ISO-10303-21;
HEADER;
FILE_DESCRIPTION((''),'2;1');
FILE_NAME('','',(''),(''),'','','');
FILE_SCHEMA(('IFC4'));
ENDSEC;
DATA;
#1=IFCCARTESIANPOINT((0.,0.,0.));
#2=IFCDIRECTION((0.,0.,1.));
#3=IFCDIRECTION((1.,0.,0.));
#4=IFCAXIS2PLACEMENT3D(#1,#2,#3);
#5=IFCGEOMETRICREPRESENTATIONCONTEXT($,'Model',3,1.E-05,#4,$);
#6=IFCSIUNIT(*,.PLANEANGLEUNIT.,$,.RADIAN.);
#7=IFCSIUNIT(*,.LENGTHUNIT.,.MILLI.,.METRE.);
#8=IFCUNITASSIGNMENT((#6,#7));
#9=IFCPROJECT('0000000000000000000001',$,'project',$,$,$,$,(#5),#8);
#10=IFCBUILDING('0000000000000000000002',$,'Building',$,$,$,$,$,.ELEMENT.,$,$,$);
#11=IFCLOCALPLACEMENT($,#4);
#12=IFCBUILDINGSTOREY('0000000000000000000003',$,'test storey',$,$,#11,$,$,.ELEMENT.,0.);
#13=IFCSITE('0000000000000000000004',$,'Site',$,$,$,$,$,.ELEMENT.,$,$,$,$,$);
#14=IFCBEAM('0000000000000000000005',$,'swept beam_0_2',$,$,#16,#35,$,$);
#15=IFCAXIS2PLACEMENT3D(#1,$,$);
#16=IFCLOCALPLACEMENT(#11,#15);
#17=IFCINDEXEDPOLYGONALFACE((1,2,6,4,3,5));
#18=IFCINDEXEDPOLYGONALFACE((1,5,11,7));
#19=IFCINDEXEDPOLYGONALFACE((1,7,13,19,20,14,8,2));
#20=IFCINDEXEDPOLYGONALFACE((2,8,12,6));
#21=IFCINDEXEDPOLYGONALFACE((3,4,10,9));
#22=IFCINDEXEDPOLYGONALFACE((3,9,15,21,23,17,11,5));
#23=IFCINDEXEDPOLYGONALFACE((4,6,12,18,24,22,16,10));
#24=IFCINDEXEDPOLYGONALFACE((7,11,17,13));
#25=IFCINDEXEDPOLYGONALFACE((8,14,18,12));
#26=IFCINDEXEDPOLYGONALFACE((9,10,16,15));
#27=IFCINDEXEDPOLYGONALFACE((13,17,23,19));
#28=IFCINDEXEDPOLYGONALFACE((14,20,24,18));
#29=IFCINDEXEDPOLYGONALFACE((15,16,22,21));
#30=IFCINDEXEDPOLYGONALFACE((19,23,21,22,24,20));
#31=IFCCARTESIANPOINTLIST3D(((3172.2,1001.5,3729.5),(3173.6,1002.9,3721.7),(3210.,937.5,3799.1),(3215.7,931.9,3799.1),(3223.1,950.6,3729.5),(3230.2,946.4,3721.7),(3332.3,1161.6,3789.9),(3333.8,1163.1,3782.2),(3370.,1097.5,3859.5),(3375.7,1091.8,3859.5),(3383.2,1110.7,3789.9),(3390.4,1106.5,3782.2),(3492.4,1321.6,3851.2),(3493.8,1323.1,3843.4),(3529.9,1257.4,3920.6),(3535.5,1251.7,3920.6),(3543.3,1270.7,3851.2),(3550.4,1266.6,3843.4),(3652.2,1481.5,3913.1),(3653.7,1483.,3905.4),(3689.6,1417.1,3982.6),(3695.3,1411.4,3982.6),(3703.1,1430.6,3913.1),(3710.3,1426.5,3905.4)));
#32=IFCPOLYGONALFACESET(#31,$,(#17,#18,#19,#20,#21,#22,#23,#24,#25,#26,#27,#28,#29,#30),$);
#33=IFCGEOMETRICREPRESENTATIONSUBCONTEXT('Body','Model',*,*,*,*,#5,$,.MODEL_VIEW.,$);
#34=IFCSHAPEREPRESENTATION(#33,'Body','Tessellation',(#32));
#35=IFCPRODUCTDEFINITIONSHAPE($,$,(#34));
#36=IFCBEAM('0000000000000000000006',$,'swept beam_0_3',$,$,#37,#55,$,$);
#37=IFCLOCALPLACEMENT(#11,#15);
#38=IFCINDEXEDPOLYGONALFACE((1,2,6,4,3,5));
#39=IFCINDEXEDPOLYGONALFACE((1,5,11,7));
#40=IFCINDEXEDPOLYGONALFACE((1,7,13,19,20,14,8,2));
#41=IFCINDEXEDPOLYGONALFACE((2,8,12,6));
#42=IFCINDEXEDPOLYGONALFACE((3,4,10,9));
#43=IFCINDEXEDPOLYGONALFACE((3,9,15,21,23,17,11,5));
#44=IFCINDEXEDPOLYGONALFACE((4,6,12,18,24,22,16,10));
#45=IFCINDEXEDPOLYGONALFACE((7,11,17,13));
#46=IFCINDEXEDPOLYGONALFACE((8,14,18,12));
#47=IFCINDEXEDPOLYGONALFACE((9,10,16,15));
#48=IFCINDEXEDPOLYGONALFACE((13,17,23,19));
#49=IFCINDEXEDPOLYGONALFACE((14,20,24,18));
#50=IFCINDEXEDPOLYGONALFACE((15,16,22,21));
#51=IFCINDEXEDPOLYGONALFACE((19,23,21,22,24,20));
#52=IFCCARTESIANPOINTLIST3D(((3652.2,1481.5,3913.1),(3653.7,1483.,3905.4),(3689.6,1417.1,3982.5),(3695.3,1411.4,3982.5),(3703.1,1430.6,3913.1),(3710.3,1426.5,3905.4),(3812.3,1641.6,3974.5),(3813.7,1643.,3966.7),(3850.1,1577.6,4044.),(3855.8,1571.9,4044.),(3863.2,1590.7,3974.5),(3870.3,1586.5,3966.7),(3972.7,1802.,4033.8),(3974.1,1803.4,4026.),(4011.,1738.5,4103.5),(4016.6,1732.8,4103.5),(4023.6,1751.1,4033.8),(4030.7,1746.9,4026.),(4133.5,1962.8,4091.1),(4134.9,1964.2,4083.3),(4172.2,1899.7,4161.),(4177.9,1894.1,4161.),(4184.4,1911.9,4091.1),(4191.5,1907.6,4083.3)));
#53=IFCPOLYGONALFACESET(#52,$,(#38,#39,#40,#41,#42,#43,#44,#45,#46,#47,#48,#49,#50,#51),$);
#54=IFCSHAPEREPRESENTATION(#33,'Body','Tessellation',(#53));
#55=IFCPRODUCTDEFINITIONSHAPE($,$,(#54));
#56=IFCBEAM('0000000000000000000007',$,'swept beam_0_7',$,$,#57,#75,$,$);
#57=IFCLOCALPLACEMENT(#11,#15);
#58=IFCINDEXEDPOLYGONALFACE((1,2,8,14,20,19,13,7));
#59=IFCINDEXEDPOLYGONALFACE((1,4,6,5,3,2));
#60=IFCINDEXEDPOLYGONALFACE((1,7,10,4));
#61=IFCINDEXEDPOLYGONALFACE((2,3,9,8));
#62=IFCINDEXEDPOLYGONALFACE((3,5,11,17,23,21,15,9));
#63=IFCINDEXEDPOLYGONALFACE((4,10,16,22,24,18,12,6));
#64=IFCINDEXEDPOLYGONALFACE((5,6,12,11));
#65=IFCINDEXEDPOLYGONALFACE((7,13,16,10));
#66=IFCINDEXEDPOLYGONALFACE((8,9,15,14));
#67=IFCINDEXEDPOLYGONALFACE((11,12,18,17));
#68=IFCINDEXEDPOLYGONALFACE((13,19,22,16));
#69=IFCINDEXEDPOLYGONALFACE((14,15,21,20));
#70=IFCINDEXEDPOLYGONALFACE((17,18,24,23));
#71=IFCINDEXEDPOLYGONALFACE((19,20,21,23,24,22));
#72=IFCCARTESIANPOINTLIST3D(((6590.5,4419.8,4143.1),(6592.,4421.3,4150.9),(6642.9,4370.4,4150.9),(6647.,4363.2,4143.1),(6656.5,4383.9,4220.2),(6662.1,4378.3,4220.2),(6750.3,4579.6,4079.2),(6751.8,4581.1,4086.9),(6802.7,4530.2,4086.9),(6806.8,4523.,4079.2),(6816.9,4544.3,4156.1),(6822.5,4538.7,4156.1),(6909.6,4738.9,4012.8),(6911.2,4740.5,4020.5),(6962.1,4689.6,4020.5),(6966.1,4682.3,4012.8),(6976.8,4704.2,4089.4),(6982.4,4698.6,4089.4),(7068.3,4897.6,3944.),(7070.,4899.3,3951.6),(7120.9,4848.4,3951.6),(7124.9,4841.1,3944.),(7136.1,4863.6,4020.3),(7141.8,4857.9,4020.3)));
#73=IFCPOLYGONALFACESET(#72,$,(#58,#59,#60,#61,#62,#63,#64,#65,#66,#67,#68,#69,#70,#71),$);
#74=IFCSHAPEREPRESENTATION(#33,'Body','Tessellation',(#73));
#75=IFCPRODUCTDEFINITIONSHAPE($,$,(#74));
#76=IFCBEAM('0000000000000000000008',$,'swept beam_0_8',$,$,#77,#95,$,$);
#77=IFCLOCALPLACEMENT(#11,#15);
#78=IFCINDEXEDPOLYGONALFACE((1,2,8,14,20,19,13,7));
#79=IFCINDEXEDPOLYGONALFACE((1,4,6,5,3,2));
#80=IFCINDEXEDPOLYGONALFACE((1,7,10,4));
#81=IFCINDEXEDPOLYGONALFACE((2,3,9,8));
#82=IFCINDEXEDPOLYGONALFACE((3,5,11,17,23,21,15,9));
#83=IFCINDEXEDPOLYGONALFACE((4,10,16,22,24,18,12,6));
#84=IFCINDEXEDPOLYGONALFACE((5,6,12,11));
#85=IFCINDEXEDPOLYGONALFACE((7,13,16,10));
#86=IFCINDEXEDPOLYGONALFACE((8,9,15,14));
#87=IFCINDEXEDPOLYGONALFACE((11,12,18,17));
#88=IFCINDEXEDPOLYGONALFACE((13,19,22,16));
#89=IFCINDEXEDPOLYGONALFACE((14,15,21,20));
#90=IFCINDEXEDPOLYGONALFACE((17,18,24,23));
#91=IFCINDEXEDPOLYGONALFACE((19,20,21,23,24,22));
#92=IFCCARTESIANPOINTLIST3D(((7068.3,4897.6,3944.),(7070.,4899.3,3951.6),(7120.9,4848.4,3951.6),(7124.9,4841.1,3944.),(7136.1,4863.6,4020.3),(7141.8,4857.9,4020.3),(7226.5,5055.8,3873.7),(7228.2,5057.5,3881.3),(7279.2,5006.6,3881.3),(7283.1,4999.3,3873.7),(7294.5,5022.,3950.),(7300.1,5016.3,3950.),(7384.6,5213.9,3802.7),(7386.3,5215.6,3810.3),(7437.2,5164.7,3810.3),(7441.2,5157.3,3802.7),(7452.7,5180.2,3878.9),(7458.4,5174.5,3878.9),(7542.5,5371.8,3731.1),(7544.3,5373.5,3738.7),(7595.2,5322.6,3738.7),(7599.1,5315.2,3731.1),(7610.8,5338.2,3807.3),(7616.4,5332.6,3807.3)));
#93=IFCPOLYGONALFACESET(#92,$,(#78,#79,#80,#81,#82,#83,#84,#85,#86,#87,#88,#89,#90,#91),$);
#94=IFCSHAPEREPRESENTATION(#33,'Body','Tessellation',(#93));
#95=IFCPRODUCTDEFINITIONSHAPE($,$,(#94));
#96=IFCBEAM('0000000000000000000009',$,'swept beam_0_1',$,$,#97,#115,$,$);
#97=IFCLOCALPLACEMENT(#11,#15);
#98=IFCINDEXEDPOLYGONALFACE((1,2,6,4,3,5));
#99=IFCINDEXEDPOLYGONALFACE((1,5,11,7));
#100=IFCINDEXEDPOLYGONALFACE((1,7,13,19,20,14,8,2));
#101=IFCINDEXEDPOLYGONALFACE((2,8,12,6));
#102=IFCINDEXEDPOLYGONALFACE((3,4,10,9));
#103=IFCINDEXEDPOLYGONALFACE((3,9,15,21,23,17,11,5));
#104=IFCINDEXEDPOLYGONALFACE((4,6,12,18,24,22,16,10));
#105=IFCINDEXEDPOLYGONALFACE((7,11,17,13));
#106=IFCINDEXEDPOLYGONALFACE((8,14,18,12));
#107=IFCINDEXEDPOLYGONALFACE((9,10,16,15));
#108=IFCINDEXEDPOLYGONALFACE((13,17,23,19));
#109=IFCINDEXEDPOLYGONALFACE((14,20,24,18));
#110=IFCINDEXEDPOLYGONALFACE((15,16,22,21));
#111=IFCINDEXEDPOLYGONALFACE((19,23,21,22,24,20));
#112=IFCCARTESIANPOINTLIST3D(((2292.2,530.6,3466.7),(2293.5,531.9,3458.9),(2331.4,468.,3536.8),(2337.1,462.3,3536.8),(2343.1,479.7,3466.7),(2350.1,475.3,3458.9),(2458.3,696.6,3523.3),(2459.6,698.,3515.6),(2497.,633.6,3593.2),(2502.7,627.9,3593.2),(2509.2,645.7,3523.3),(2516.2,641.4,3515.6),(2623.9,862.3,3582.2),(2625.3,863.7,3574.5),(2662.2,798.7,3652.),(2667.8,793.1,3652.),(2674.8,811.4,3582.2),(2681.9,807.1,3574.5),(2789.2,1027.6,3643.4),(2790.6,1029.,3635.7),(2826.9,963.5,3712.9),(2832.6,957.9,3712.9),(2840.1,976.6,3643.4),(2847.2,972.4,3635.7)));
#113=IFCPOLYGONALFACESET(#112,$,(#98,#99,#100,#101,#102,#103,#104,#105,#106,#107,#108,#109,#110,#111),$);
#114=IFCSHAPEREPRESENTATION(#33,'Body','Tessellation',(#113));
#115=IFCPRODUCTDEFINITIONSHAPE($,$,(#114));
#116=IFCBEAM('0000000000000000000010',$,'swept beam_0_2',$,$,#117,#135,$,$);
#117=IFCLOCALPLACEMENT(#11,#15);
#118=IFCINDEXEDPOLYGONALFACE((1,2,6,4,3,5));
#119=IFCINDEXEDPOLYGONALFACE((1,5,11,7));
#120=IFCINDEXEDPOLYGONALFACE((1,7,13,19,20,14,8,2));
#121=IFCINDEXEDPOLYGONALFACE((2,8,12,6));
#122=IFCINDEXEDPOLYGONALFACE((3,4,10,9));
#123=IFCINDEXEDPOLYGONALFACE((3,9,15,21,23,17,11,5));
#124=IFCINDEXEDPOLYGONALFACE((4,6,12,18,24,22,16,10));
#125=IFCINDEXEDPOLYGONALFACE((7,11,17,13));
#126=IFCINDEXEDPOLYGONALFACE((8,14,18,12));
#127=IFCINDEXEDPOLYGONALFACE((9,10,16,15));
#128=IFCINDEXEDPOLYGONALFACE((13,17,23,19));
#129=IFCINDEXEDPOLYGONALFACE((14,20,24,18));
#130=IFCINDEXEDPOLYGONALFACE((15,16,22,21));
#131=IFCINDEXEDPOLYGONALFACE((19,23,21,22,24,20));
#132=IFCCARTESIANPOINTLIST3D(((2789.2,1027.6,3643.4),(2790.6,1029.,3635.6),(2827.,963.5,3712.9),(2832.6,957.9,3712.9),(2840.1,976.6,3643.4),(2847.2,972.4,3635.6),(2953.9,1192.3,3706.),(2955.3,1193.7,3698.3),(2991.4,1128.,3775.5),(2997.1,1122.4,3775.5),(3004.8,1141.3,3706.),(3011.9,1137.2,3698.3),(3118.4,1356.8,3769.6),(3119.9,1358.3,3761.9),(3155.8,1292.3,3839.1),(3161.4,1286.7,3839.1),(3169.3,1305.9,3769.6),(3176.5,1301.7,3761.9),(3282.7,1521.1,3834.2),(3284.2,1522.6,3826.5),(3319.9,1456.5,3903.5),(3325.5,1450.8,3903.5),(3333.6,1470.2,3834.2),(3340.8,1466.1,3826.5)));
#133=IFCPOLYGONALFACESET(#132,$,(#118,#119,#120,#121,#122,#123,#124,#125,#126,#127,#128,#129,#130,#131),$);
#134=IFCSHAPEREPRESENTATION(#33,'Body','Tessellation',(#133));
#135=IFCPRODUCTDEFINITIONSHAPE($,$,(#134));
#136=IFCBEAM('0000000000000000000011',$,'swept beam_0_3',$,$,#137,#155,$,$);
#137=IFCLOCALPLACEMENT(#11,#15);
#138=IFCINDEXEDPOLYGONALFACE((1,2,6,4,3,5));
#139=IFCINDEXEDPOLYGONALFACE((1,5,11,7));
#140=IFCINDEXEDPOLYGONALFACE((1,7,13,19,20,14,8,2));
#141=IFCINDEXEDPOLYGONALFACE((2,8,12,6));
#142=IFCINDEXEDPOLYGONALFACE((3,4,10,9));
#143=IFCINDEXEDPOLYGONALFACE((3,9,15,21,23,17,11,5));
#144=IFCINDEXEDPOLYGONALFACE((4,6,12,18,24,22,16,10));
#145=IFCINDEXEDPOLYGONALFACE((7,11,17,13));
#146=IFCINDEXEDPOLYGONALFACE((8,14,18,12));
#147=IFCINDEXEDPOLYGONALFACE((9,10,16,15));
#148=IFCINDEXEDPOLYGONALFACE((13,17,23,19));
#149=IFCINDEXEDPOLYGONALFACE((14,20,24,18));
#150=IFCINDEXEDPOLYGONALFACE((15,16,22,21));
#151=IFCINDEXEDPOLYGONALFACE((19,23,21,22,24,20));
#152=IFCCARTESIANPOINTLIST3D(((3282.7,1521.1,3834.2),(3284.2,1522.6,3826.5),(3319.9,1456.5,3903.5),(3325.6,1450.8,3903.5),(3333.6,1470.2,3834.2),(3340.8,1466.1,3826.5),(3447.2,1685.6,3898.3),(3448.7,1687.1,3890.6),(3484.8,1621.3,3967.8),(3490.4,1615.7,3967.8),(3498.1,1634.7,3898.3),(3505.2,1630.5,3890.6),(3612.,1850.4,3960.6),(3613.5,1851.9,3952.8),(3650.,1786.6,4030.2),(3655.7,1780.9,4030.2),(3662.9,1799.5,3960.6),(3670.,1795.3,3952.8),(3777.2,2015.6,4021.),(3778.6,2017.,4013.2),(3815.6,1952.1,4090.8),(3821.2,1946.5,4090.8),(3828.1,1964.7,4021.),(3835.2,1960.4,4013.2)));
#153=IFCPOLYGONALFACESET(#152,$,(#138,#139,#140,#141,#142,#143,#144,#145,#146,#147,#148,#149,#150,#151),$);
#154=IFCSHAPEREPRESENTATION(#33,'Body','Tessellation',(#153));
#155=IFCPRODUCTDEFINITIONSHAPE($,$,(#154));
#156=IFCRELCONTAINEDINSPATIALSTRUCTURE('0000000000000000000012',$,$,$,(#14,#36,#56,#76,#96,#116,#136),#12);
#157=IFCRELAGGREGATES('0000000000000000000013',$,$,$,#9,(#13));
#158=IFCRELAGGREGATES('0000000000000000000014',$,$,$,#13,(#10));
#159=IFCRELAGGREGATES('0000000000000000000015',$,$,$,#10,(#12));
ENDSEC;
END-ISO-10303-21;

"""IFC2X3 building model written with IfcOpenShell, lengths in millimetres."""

from ifc_helpers import new_model, entity, si_unit, origin_with_axes, place, context, subcontext, project, spatial, element, save


model = new_model("IFC2X3")

# Units and contexts
model_context = context("Model", 3, precision=1e-05, world=origin_with_axes())
body_context = subcontext(model_context, "Body", "Model", "MODEL_VIEW")
ifc_project = project(units=[si_unit("PLANEANGLEUNIT", "RADIAN"), si_unit("LENGTHUNIT", "METRE", prefix="MILLI")], contexts=[model_context])

# Site, building, storey
site = spatial("IfcSite", under=ifc_project, Name="Site", CompositionType="ELEMENT")
building = spatial("IfcBuilding", under=site, Name="Building", CompositionType="ELEMENT")
storey_placement = place(None, origin_with_axes())
storey = spatial("IfcBuildingStorey", under=building, at=storey_placement, Name="test storey", CompositionType="ELEMENT", Elevation=0.0)

# Beams
beam_1_placement = place(storey_placement, origin_with_axes())
element("IfcBeam", 1, at=beam_1_placement, inside=storey, Name="swept beam_0_2", context=body_context, shape_type="SweptSolid", body=[
    entity("IfcRevolvedAreaSolid", entity("IfcArbitraryClosedProfileDef", "AREA", None, entity("IfcPolyline", [entity("IfcCartesianPoint", [-80.0, 40.0]), entity("IfcCartesianPoint", [-80.0, 32.0]), entity("IfcCartesianPoint", [-8.0, 32.0]), entity("IfcCartesianPoint", [-8.0, -40.0]), entity("IfcCartesianPoint", [0.0, -40.0]), entity("IfcCartesianPoint", [0.0, 40.0]), entity("IfcCartesianPoint", [-80.0, 40.0])])), entity("IfcAxis2Placement3D", entity("IfcCartesianPoint", [3201.9, 974.6, 3721.7]), entity("IfcDirection", [-0.6835, -0.6835, -0.2564]), entity("IfcDirection", [0.1813, 0.1813, -0.9666])), entity("IfcAxis1Placement", entity("IfcCartesianPoint", [-70891.4, 0.0, 0.0]), entity("IfcDirection", [0.0, 1.0, 0.0])), 0.009922),
])
beam_2_placement = place(storey_placement, origin_with_axes())
element("IfcBeam", 2, at=beam_2_placement, inside=storey, Name="swept beam_0_3", context=body_context, shape_type="SweptSolid", body=[
    entity("IfcRevolvedAreaSolid", entity("IfcArbitraryClosedProfileDef", "AREA", None, entity("IfcPolyline", [entity("IfcCartesianPoint", [80.0, -40.0]), entity("IfcCartesianPoint", [80.0, -32.0]), entity("IfcCartesianPoint", [8.0, -32.0]), entity("IfcCartesianPoint", [8.0, 40.0]), entity("IfcCartesianPoint", [0.0, 40.0]), entity("IfcCartesianPoint", [0.0, -40.0]), entity("IfcCartesianPoint", [80.0, -40.0])])), entity("IfcAxis2Placement3D", entity("IfcCartesianPoint", [3682.0, 1454.7, 3905.4]), entity("IfcDirection", [-0.6816, -0.6816, -0.2659]), entity("IfcDirection", [-0.188, -0.188, 0.964])), entity("IfcAxis1Placement", entity("IfcCartesianPoint", [-26110.2, 0.0, 0.0]), entity("IfcDirection", [0.0, 1.0, 0.0])), 0.026938),
])
beam_3_placement = place(storey_placement, origin_with_axes())
element("IfcBeam", 3, at=beam_3_placement, inside=storey, Name="swept beam_0_7", context=body_context, shape_type="SweptSolid", body=[
    entity("IfcRevolvedAreaSolid", entity("IfcArbitraryClosedProfileDef", "AREA", None, entity("IfcPolyline", [entity("IfcCartesianPoint", [80.0, -40.0]), entity("IfcCartesianPoint", [80.0, -32.0]), entity("IfcCartesianPoint", [8.0, -32.0]), entity("IfcCartesianPoint", [8.0, 40.0]), entity("IfcCartesianPoint", [0.0, 40.0]), entity("IfcCartesianPoint", [0.0, -40.0]), entity("IfcCartesianPoint", [80.0, -40.0])])), entity("IfcAxis2Placement3D", entity("IfcCartesianPoint", [6618.7, 4391.5, 4143.1]), entity("IfcDirection", [-0.6815, -0.6815, 0.2669]), entity("IfcDirection", [0.1887, 0.1887, 0.9637])), entity("IfcAxis1Placement", entity("IfcCartesianPoint", [-21441.5, 0.0, 0.0]), entity("IfcDirection", [0.0, 1.0, 0.0])), 0.03286),
])
beam_4_placement = place(storey_placement, origin_with_axes())
element("IfcBeam", 4, at=beam_4_placement, inside=storey, Name="swept beam_0_8", context=body_context, shape_type="SweptSolid", body=[
    entity("IfcRevolvedAreaSolid", entity("IfcArbitraryClosedProfileDef", "AREA", None, entity("IfcPolyline", [entity("IfcCartesianPoint", [80.0, -40.0]), entity("IfcCartesianPoint", [80.0, -32.0]), entity("IfcCartesianPoint", [8.0, -32.0]), entity("IfcCartesianPoint", [8.0, 40.0]), entity("IfcCartesianPoint", [0.0, 40.0]), entity("IfcCartesianPoint", [0.0, -40.0]), entity("IfcCartesianPoint", [80.0, -40.0])])), entity("IfcAxis2Placement3D", entity("IfcCartesianPoint", [7096.6, 4869.3, 3944.0]), entity("IfcDirection", [-0.6749, -0.6749, 0.2984]), entity("IfcDirection", [0.211, 0.211, 0.9544])), entity("IfcAxis1Placement", entity("IfcCartesianPoint", [-81060.5, 0.0, 0.0]), entity("IfcDirection", [0.0, 1.0, 0.0])), 0.00868),
])
beam_5_placement = place(storey_placement, origin_with_axes())
element("IfcBeam", 5, at=beam_5_placement, inside=storey, Name="swept beam_0_1", context=body_context, shape_type="SweptSolid", body=[
    entity("IfcRevolvedAreaSolid", entity("IfcArbitraryClosedProfileDef", "AREA", None, entity("IfcPolyline", [entity("IfcCartesianPoint", [-80.0, 40.0]), entity("IfcCartesianPoint", [-80.0, 32.0]), entity("IfcCartesianPoint", [-8.0, 32.0]), entity("IfcCartesianPoint", [-8.0, -40.0]), entity("IfcCartesianPoint", [0.0, -40.0]), entity("IfcCartesianPoint", [0.0, 40.0]), entity("IfcCartesianPoint", [-80.0, 40.0])])), entity("IfcAxis2Placement3D", entity("IfcCartesianPoint", [2321.8, 503.6, 3458.9]), entity("IfcDirection", [-0.6882, -0.6882, -0.2296]), entity("IfcDirection", [0.1623, 0.1623, -0.9733])), entity("IfcAxis1Placement", entity("IfcCartesianPoint", [-24819.4, 0.0, 0.0]), entity("IfcDirection", [0.0, 1.0, 0.0])), 0.029209),
])
beam_6_placement = place(storey_placement, origin_with_axes())
element("IfcBeam", 6, at=beam_6_placement, inside=storey, Name="swept beam_0_2", context=body_context, shape_type="SweptSolid", body=[
    entity("IfcRevolvedAreaSolid", entity("IfcArbitraryClosedProfileDef", "AREA", None, entity("IfcPolyline", [entity("IfcCartesianPoint", [-80.0, 40.0]), entity("IfcCartesianPoint", [-80.0, 32.0]), entity("IfcCartesianPoint", [-8.0, 32.0]), entity("IfcCartesianPoint", [-8.0, -40.0]), entity("IfcCartesianPoint", [0.0, -40.0]), entity("IfcCartesianPoint", [0.0, 40.0]), entity("IfcCartesianPoint", [-80.0, 40.0])])), entity("IfcAxis2Placement3D", entity("IfcCartesianPoint", [2818.9, 1000.7, 3635.6]), entity("IfcDirection", [-0.6832, -0.6832, -0.2579]), entity("IfcDirection", [0.1824, 0.1824, -0.9662])), entity("IfcAxis1Placement", entity("IfcCartesianPoint", [-59488.3, 0.0, 0.0]), entity("IfcDirection", [0.0, 1.0, 0.0])), 0.012165),
])
beam_7_placement = place(storey_placement, origin_with_axes())
element("IfcBeam", 7, at=beam_7_placement, inside=storey, Name="swept beam_0_3", context=body_context, shape_type="SweptSolid", body=[
    entity("IfcRevolvedAreaSolid", entity("IfcArbitraryClosedProfileDef", "AREA", None, entity("IfcPolyline", [entity("IfcCartesianPoint", [80.0, -40.0]), entity("IfcCartesianPoint", [80.0, -32.0]), entity("IfcCartesianPoint", [8.0, -32.0]), entity("IfcCartesianPoint", [8.0, 40.0]), entity("IfcCartesianPoint", [0.0, 40.0]), entity("IfcCartesianPoint", [0.0, -40.0]), entity("IfcCartesianPoint", [80.0, -40.0])])), entity("IfcAxis2Placement3D", entity("IfcCartesianPoint", [3312.5, 1494.3, 3826.5]), entity("IfcDirection", [-0.6809, -0.6809, -0.2696]), entity("IfcDirection", [-0.1907, -0.1907, 0.963])), entity("IfcAxis1Placement", entity("IfcCartesianPoint", [-30111.5, 0.0, 0.0]), entity("IfcDirection", [0.0, 1.0, 0.0])), 0.024033),
])

save(model, "model.ifc")
